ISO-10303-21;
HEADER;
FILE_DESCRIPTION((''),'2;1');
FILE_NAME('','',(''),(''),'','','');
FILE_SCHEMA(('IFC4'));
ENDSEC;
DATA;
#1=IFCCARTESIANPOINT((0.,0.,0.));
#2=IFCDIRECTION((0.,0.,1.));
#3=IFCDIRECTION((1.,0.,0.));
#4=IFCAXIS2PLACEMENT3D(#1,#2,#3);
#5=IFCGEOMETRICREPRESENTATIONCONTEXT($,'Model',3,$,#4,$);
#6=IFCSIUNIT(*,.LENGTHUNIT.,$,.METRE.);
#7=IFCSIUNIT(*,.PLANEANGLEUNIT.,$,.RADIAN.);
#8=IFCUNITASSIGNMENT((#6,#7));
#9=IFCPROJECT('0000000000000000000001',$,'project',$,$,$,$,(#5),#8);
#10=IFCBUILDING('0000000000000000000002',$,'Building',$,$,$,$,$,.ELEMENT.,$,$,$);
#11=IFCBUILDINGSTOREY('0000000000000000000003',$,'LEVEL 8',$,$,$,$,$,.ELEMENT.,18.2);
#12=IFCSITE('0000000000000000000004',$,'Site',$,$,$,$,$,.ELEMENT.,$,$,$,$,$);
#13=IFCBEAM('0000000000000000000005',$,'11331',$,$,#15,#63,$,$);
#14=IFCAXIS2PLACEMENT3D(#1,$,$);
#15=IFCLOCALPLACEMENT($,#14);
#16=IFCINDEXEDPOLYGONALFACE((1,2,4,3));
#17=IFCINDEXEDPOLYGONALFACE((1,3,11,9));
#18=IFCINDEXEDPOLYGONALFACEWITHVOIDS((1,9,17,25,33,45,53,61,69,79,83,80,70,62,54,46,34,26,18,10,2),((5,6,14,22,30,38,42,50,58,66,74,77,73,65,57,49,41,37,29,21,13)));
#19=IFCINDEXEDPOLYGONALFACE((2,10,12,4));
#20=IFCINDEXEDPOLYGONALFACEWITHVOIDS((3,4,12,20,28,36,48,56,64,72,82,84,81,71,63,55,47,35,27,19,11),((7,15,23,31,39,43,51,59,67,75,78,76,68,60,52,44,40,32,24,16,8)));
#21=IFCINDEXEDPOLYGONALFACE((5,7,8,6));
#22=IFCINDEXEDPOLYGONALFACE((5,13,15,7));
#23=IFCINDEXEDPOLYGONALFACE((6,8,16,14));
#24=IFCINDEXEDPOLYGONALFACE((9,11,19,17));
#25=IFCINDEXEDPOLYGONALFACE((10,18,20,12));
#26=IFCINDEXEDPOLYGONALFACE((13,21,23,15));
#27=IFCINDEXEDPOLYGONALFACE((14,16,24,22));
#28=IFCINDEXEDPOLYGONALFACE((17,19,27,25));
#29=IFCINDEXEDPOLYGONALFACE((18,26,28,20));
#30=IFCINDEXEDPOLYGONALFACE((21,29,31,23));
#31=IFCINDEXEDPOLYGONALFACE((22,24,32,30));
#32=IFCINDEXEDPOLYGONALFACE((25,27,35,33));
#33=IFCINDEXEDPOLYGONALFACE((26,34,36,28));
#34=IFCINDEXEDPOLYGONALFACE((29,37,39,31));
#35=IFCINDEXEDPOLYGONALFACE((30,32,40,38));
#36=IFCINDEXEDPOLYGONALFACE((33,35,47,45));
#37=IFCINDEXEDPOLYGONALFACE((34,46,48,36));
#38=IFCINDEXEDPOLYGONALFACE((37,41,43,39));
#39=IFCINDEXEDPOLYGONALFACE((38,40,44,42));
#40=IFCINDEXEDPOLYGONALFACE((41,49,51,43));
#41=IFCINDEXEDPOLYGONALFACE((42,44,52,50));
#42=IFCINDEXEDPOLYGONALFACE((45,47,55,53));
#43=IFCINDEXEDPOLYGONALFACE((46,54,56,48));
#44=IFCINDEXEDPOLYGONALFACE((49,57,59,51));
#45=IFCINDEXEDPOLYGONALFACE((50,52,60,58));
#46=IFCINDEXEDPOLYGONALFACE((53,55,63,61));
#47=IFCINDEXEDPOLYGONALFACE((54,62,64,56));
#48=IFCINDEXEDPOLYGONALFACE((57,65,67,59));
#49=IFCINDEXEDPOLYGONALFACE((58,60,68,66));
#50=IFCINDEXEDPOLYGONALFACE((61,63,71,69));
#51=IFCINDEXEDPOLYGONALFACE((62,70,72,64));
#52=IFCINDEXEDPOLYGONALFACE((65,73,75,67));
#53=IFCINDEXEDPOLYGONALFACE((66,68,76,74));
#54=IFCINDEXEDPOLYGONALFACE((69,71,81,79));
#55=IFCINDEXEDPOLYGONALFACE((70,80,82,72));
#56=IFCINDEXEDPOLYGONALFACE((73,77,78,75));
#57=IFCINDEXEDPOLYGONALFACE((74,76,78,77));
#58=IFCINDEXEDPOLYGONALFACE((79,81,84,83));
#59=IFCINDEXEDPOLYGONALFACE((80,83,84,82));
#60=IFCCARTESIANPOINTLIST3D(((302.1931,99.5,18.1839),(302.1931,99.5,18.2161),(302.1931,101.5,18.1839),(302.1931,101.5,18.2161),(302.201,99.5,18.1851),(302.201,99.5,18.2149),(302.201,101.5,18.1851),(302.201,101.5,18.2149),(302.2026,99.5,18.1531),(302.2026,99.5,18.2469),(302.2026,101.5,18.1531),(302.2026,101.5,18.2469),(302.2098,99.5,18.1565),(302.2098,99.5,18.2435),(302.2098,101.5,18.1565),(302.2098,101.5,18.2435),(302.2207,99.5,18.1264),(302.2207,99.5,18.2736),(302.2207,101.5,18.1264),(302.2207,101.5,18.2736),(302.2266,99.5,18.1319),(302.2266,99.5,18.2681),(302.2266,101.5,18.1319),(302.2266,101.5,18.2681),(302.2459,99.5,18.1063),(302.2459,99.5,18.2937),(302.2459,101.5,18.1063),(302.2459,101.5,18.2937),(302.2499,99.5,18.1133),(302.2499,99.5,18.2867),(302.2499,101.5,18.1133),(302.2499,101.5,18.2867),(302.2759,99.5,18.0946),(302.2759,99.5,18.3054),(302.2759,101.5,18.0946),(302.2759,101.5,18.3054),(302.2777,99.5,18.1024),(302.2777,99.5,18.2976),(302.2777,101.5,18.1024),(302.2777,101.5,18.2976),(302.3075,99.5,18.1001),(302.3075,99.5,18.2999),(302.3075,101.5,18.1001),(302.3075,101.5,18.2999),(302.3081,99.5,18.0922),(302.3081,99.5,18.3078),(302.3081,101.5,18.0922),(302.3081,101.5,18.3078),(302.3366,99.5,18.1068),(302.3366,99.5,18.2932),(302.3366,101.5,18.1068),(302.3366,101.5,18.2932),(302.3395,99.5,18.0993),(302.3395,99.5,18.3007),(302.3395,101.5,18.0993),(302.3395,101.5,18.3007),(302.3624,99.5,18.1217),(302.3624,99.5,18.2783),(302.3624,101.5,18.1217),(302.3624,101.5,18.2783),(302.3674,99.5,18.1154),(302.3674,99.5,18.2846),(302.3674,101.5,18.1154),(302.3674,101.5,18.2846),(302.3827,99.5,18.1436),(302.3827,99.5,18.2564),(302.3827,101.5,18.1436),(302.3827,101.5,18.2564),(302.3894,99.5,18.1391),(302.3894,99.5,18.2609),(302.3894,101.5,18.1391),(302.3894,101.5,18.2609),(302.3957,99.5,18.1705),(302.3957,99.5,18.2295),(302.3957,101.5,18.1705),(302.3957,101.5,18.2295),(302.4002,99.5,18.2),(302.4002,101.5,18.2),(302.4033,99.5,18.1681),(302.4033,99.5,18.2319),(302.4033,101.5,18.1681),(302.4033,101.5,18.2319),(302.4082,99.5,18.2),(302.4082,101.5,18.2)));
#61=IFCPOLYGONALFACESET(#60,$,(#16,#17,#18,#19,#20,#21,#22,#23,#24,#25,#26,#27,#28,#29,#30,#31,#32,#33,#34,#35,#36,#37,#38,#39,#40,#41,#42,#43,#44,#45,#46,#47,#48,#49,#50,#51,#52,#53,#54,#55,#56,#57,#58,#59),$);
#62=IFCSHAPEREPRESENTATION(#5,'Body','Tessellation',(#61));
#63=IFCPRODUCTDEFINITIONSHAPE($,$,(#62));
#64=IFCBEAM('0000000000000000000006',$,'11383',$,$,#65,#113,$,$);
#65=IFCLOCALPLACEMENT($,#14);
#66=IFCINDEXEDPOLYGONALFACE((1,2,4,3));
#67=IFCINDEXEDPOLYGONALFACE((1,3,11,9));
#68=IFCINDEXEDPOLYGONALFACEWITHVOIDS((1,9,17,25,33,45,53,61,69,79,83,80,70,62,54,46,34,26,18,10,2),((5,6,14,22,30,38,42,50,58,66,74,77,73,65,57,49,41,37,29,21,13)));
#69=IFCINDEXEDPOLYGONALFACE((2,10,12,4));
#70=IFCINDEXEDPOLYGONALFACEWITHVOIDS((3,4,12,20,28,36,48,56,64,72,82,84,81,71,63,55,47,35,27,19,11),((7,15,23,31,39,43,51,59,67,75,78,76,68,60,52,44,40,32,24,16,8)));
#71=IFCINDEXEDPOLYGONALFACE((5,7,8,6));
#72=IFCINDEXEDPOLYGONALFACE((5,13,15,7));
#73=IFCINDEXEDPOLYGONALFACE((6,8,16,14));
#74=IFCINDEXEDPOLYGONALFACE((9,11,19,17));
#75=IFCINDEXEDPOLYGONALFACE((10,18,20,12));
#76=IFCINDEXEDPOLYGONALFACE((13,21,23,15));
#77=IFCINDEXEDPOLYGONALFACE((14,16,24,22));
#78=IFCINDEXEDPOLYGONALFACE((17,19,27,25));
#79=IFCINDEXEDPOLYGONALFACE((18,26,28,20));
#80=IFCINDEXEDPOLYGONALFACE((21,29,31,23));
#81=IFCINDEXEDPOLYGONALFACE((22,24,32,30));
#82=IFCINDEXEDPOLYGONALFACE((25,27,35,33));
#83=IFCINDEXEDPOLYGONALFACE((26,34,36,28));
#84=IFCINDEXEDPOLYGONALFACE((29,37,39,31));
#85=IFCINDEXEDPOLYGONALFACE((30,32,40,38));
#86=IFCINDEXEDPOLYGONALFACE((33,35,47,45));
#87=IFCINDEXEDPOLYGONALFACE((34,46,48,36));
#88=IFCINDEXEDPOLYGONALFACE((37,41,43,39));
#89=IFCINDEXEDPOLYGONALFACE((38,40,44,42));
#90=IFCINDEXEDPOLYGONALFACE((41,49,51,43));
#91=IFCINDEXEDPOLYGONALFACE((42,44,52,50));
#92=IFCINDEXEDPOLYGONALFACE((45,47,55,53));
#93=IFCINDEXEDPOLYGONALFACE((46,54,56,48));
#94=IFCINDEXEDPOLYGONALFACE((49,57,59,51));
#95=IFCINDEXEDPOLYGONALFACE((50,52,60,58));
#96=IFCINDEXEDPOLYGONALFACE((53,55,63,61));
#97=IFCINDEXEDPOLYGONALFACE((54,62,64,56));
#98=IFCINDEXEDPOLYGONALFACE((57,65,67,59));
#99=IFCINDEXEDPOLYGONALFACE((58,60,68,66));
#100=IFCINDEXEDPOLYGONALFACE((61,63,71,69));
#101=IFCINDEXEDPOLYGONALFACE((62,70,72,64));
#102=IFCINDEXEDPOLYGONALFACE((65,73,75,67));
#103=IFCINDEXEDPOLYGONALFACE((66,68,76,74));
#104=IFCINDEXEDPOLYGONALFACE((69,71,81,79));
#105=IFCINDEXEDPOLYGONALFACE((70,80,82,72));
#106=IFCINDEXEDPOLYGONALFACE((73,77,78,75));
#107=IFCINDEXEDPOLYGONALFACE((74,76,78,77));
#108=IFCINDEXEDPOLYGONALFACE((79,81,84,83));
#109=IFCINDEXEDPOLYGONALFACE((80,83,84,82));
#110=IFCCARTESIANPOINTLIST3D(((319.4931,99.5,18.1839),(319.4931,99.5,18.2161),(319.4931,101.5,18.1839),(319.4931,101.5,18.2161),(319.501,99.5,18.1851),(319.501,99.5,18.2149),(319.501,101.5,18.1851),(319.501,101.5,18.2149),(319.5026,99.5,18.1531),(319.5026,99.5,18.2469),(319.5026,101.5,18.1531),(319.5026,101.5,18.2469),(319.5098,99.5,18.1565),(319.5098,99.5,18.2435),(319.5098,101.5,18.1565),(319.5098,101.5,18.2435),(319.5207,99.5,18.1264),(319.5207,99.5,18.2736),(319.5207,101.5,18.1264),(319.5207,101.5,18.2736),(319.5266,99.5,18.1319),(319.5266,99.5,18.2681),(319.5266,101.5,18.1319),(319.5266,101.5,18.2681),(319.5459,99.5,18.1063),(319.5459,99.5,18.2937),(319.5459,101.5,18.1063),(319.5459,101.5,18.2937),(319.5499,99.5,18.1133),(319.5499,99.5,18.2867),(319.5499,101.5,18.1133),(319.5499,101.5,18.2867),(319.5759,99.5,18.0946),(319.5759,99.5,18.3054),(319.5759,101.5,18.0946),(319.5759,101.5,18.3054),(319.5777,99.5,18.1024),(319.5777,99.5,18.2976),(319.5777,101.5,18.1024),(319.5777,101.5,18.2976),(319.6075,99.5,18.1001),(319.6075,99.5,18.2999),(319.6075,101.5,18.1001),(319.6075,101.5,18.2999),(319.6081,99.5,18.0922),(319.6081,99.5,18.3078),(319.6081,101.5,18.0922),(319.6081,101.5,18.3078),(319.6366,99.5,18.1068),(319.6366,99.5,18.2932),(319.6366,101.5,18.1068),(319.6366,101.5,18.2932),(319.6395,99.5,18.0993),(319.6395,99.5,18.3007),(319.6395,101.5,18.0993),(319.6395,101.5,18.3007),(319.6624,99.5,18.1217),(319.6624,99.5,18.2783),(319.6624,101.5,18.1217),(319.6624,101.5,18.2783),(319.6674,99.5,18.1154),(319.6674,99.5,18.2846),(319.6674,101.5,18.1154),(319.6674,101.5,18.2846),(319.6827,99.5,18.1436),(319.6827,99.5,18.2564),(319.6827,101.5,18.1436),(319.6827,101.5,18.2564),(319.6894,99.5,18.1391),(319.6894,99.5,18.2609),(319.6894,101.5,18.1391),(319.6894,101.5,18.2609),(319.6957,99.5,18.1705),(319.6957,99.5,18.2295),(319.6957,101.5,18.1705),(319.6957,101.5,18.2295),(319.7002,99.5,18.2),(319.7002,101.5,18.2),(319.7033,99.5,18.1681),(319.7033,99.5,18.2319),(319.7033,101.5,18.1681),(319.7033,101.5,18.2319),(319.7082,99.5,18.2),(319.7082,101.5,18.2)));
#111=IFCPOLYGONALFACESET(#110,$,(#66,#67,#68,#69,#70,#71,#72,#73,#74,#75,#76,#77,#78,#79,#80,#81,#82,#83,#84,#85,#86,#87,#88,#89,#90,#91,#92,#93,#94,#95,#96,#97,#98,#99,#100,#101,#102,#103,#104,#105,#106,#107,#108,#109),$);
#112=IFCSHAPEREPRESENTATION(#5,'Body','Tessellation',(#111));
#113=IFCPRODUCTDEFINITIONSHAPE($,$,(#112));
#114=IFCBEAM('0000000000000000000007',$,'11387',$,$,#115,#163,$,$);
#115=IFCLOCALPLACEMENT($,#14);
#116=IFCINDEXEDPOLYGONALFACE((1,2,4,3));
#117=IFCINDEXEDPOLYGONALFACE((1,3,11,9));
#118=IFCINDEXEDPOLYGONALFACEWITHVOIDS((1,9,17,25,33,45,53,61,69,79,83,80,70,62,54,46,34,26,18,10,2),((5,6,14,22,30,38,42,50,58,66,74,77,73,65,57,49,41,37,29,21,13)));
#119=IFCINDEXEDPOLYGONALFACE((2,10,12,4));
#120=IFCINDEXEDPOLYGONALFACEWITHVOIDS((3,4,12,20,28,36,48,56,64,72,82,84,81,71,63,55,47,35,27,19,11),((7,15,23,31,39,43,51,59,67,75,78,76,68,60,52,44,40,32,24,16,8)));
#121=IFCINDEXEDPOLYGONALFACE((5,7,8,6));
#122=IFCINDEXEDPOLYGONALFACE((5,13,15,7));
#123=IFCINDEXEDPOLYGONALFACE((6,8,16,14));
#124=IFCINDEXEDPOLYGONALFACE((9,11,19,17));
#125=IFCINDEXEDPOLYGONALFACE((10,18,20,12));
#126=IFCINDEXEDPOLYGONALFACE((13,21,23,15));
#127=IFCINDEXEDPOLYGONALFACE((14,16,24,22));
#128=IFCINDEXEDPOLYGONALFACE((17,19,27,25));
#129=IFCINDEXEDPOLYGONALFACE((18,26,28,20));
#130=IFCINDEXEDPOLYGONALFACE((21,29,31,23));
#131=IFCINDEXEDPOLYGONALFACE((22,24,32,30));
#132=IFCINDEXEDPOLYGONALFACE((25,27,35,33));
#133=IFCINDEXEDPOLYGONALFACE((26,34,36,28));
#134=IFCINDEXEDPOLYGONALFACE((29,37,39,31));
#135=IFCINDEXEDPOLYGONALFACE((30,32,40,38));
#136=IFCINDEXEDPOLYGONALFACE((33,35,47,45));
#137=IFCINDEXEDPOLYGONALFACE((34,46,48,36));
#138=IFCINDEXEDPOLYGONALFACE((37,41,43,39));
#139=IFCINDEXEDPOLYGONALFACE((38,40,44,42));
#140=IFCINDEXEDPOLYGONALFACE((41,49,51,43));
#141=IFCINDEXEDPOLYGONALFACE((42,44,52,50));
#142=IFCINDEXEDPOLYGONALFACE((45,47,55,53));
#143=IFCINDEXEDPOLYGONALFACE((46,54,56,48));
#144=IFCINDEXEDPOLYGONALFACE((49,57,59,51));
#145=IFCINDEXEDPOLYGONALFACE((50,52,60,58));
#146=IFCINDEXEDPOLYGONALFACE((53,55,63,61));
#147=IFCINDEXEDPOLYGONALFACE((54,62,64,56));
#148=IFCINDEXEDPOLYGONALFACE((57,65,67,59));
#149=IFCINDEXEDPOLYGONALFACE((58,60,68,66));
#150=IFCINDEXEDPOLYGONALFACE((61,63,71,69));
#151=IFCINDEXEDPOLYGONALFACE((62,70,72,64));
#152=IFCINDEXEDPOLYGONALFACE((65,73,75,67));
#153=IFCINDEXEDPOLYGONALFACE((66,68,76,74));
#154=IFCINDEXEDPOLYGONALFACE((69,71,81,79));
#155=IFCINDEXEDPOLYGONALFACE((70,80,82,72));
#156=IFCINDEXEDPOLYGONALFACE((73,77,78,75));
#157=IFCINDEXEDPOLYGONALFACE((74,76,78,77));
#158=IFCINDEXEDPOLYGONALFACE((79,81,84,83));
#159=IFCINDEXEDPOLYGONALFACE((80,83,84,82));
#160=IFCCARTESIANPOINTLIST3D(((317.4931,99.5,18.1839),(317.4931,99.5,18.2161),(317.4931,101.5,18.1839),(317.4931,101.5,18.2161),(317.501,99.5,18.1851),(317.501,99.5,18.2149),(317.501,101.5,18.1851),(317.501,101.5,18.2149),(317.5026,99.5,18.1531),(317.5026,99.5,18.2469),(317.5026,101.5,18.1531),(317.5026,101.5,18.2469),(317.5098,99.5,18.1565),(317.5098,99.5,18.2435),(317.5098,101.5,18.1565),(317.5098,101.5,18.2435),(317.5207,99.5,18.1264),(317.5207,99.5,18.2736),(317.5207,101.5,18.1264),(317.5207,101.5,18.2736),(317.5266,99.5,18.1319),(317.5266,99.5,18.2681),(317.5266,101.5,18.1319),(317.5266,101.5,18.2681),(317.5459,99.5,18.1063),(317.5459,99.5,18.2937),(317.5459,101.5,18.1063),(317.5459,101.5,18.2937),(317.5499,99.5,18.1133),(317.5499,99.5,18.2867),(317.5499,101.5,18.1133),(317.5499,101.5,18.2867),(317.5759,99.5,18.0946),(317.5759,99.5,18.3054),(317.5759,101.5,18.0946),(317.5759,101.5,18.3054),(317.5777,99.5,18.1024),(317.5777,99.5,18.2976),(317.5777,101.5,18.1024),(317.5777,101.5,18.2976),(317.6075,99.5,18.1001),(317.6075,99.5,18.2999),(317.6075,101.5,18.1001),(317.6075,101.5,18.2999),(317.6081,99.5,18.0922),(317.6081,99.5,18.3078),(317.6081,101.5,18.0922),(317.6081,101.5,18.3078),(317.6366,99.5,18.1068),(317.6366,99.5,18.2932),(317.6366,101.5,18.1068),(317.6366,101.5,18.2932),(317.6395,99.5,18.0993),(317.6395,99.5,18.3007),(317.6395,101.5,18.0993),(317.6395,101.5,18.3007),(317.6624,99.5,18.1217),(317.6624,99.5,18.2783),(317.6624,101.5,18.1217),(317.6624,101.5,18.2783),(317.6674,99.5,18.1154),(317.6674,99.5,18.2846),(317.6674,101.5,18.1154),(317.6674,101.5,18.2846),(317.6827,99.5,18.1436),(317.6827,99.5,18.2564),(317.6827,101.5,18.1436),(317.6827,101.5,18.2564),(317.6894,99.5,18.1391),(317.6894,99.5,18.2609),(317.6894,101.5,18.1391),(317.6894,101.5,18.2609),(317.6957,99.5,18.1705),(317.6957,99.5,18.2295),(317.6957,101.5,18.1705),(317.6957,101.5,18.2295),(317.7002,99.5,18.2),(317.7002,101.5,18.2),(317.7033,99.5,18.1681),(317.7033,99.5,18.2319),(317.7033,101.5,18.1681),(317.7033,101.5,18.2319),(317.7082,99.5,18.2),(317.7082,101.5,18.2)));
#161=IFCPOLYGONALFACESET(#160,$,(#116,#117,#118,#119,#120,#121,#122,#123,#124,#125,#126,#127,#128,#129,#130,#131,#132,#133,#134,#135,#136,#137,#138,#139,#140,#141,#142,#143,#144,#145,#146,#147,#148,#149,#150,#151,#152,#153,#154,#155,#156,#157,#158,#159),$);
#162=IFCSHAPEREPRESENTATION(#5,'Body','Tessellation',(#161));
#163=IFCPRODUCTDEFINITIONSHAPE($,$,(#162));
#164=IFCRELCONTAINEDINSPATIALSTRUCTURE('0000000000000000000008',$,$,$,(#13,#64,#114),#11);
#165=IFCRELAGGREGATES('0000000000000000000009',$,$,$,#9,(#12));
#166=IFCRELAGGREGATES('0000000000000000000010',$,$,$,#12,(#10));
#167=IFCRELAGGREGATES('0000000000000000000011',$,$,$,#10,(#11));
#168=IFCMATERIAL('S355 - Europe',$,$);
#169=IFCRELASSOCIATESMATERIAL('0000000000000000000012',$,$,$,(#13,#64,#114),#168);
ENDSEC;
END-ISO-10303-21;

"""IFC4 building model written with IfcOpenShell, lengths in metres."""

from ifc_helpers import new_model, si_unit, frame, origin_with_axes, origin_2d_with_axis, place, context, project, spatial, hollow_circle, extrude, material, material_profile, profile_set, profile_usage, element, save


model = new_model("IFC4")

# Units and contexts
model_context = context("Model", 3, world=origin_with_axes())
ifc_project = project(units=[si_unit("LENGTHUNIT", "METRE"), si_unit("PLANEANGLEUNIT", "RADIAN")], contexts=[model_context])

# Site, building, storey
site = spatial("IfcSite", under=ifc_project, Name="Site", CompositionType="ELEMENT")
building = spatial("IfcBuilding", under=site, Name="Building", CompositionType="ELEMENT")
storey = spatial("IfcBuildingStorey", under=building, Name="LEVEL 8", CompositionType="ELEMENT", Elevation=18.2)

# Shared definitions
ifc_material = material(Name="S355 - Europe")

# Beams
ifc_material_profile_1 = material_profile(ifc_material, hollow_circle(Radius=0.1081, WallThickness=0.008, at=origin_2d_with_axis()))
ifc_profile_set_1 = profile_set([ifc_material_profile_1])
ifc_profile_usage_1 = profile_usage(ifc_profile_set_1, cardinal=10)
beam_1_placement = place(None, frame((302.3, 101.5, 18.2), z_axis=(0.0, -1.0, 0.0), x_axis=(1.0, 0.0, 0.0)))
element("IfcBeam", 1, at=beam_1_placement, inside=storey, material=ifc_profile_usage_1, Name="11331", context=model_context, shape_type="SweptSolid", body=[
    extrude(hollow_circle(Radius=0.1081, WallThickness=0.008, at=origin_2d_with_axis()), origin_with_axes(), (0.0, 0.0, 1.0), 2.0),
])
ifc_material_profile_2 = material_profile(ifc_material, hollow_circle(Radius=0.1081, WallThickness=0.008, at=origin_2d_with_axis()))
ifc_profile_set_2 = profile_set([ifc_material_profile_2])
ifc_profile_usage_2 = profile_usage(ifc_profile_set_2, cardinal=10)
beam_2_placement = place(None, frame((319.6, 101.5, 18.2), z_axis=(0.0, -1.0, 0.0), x_axis=(1.0, 0.0, 0.0)))
element("IfcBeam", 2, at=beam_2_placement, inside=storey, material=ifc_profile_usage_2, Name="11383", context=model_context, shape_type="SweptSolid", body=[
    extrude(hollow_circle(Radius=0.1081, WallThickness=0.008, at=origin_2d_with_axis()), origin_with_axes(), (0.0, 0.0, 1.0), 2.0),
])
ifc_material_profile_3 = material_profile(ifc_material, hollow_circle(Radius=0.1081, WallThickness=0.008, at=origin_2d_with_axis()))
ifc_profile_set_3 = profile_set([ifc_material_profile_3])
ifc_profile_usage_3 = profile_usage(ifc_profile_set_3, cardinal=10)
beam_3_placement = place(None, frame((317.6, 101.5, 18.2), z_axis=(0.0, -1.0, 0.0), x_axis=(1.0, 0.0, 0.0)))
element("IfcBeam", 3, at=beam_3_placement, inside=storey, material=ifc_profile_usage_3, Name="11387", context=model_context, shape_type="SweptSolid", body=[
    extrude(hollow_circle(Radius=0.1081, WallThickness=0.008, at=origin_2d_with_axis()), origin_with_axes(), (0.0, 0.0, 1.0), 2.0),
])

save(model, "model.ifc")
